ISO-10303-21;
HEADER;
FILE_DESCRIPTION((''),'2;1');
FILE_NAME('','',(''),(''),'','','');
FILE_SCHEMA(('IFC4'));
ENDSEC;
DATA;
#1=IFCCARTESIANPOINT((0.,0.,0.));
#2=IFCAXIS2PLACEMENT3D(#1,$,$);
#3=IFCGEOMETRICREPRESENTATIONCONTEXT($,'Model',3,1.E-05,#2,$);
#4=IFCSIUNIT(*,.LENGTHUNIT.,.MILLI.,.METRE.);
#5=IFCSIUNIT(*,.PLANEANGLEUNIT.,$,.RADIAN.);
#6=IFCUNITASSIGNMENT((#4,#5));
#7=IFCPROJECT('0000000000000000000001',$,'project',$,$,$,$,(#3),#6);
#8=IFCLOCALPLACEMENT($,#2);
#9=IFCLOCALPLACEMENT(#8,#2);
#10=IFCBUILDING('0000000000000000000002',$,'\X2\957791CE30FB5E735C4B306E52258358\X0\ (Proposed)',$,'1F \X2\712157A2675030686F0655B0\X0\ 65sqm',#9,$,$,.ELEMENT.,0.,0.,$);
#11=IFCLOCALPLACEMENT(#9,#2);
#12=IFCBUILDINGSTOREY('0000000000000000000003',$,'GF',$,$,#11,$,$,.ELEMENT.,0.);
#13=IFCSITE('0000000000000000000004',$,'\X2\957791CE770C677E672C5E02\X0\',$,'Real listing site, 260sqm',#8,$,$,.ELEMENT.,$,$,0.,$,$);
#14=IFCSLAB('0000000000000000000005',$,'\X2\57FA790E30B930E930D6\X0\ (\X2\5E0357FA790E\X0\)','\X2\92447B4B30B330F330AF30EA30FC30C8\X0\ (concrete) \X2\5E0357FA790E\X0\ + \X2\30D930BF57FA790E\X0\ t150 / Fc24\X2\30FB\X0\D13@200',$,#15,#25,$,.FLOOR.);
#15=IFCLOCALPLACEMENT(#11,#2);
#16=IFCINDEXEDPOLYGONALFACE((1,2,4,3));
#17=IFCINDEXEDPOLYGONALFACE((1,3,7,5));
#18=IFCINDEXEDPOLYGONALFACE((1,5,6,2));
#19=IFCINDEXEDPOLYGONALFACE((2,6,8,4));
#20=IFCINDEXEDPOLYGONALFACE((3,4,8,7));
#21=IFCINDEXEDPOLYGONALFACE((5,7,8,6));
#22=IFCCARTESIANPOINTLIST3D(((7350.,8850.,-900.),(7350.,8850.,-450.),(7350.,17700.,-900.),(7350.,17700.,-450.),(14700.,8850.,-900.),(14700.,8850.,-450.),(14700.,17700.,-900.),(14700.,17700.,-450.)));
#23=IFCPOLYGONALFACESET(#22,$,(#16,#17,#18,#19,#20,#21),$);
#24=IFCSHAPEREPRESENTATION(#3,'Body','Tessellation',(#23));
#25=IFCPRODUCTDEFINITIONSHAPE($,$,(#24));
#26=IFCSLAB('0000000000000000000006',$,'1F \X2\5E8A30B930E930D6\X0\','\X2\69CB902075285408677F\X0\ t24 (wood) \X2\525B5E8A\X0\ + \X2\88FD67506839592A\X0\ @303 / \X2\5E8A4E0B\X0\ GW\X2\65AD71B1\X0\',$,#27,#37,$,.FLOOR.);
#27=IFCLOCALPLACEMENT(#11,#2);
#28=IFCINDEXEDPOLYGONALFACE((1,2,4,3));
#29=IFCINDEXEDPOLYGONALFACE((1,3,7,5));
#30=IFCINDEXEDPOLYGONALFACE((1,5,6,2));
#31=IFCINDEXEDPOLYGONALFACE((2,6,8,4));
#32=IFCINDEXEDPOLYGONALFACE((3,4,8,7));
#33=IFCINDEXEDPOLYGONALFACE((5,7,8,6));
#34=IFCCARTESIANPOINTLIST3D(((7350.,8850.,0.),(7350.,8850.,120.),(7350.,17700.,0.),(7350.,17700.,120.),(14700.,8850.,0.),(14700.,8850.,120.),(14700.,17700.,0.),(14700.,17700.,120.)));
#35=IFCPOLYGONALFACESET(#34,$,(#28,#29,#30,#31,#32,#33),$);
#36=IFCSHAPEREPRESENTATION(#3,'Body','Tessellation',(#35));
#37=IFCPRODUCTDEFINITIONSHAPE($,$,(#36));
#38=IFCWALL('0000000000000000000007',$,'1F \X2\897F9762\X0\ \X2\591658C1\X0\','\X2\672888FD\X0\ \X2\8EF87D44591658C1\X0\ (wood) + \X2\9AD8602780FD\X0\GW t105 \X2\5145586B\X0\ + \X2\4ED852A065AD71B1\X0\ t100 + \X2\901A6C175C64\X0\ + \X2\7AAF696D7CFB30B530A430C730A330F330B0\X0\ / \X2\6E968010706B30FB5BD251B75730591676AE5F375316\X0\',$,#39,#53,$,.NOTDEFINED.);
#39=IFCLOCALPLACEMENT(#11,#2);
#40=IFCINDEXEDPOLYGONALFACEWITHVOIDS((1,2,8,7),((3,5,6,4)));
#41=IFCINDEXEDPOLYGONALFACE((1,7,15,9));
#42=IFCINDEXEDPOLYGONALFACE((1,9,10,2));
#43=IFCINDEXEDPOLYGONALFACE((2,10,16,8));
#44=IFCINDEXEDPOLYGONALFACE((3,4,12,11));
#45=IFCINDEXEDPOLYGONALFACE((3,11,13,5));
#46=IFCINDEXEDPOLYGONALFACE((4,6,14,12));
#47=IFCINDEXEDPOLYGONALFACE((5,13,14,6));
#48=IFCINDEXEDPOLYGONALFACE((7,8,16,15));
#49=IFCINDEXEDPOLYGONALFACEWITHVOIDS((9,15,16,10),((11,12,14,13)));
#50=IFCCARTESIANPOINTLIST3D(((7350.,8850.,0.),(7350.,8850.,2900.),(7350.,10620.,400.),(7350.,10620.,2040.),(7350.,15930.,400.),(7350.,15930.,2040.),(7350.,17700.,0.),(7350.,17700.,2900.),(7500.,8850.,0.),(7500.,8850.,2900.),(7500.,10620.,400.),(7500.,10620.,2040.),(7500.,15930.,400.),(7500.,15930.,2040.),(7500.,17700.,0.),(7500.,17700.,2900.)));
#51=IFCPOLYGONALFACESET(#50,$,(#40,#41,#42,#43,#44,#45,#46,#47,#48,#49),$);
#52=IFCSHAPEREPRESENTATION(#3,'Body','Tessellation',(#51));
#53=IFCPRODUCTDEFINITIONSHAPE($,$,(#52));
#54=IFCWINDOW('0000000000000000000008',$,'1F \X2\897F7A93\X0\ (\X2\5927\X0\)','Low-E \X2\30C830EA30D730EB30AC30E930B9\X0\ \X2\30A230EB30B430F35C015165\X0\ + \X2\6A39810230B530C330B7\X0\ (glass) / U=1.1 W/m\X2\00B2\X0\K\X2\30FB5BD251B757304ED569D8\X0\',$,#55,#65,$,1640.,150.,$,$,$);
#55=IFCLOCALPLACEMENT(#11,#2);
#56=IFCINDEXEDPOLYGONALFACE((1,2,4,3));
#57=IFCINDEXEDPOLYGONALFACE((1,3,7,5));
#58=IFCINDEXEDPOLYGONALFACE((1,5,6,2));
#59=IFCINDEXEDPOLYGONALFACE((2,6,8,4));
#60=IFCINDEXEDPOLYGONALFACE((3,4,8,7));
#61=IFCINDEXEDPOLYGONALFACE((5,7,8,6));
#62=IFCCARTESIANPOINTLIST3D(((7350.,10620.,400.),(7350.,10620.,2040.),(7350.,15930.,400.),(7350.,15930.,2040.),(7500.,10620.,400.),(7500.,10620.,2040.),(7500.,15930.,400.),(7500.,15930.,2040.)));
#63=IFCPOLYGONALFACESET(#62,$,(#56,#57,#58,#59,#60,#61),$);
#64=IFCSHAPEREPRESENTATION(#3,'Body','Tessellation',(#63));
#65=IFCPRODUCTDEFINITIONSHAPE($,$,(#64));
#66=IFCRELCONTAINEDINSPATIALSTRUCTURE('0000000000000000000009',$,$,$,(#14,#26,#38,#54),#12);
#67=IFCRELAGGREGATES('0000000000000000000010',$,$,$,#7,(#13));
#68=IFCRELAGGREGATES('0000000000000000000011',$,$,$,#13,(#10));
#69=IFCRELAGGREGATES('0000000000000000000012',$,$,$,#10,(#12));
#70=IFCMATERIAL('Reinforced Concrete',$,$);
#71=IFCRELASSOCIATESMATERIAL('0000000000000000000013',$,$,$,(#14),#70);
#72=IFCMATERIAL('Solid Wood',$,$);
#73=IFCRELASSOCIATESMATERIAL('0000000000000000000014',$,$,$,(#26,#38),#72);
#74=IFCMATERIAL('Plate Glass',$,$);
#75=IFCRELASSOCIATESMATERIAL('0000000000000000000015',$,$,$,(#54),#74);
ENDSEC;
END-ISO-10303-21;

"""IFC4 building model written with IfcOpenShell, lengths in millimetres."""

from ifc_helpers import new_model, si_unit, frame, frame_2d, origin, place, context, project, spatial, rectangle, extrude, material, element, fill, save


model = new_model("IFC4")

# Units and contexts
model_context = context("Model", 3, precision=1e-05, world=origin())
ifc_project = project(units=[si_unit("LENGTHUNIT", "METRE", prefix="MILLI"), si_unit("PLANEANGLEUNIT", "RADIAN")], contexts=[model_context])

# Site, building, storey
site_placement = place(None, origin())
site = spatial("IfcSite", under=ifc_project, at=site_placement, Name="長野県松本市", ObjectType="Real listing site, 260sqm", CompositionType="ELEMENT", RefElevation=0.0)
building_placement = place(site_placement, origin())
building = spatial("IfcBuilding", under=site, at=building_placement, Name="長野・平屋の別荘 (Proposed)", ObjectType="1F 無垢材と漆喰 65sqm", CompositionType="ELEMENT", ElevationOfRefHeight=0.0, ElevationOfTerrain=0.0)
storey_placement = place(building_placement, origin())
storey = spatial("IfcBuildingStorey", under=building, at=storey_placement, Name="GF", CompositionType="ELEMENT", Elevation=0.0)

# Shared definitions
ifc_material_1 = material(Name="Solid Wood")

# Slabs
ifc_material_2 = material(Name="Reinforced Concrete")
slab_1_placement = place(storey_placement, frame((3675.0, 4425.0, -450.0)))
element("IfcSlab", 1, at=slab_1_placement, inside=storey, material=ifc_material_2, Name="基礎スラブ (布基礎)", Description="鉄筋コンクリート (concrete) 布基礎 + ベタ基礎 t150 / Fc24・D13@200", PredefinedType="FLOOR", context=model_context, shape_type="SweptSolid", body=[
    extrude(rectangle(XDim=7350.0, YDim=8850.0, at=frame_2d((3675.0, 4425.0))), frame((3675.0, 4425.0, -450.0)), (0.0, 0.0, 1.0), 450.0),
])
slab_2_placement = place(storey_placement, frame((3675.0, 4425.0, 0.0)))
element("IfcSlab", 2, at=slab_2_placement, inside=storey, material=ifc_material_1, Name="1F 床スラブ", Description="構造用合板 t24 (wood) 剛床 + 製材根太 @303 / 床下 GW断熱", PredefinedType="FLOOR", context=model_context, shape_type="SweptSolid", body=[
    extrude(rectangle(XDim=7350.0, YDim=8850.0, at=frame_2d((3675.0, 4425.0))), frame((3675.0, 4425.0, 0.0)), (0.0, 0.0, 1.0), 120.0),
])

# Shared definitions
ifc_material_3 = material(Name="Plate Glass")

# Wall, opening, window
wall_1_placement = place(storey_placement, frame((3675.0, 4425.0, 0.0)))
wall_1 = element("IfcWall", 3, at=wall_1_placement, inside=storey, material=ifc_material_1, Name="1F 西面 外壁", Description="木製 軸組外壁 (wood) + 高性能GW t105 充填 + 付加断熱 t100 + 通気層 + 窯業系サイディング / 準耐火・寒冷地外皮強化", PredefinedType="NOTDEFINED", context=model_context, shape_type="SweptSolid", body=[
    extrude(rectangle(XDim=150.0, YDim=8850.0, at=frame_2d((75.0, 4425.0))), frame((3675.0, 4425.0, 0.0)), (0.0, 0.0, 1.0), 2900.0),
])
opening_1_placement = place(storey_placement, frame((3675.0, 5310.0, 200.0)))
opening_1 = element("IfcOpeningElement", 4, at=opening_1_placement, cuts=wall_1, PredefinedType="NOTDEFINED", context=model_context, shape_type="SweptSolid", body=[
    extrude(rectangle(XDim=150.0, YDim=5310.0, at=frame_2d((75.0, 2655.0))), frame((3675.0, 5310.0, 200.0)), (0.0, 0.0, 1.0), 1640.0),
])
window_1_placement = place(storey_placement, frame((3675.0, 5310.0, 200.0)))
window_1 = element("IfcWindow", 5, at=window_1_placement, inside=storey, material=ifc_material_3, Name="1F 西窓 (大)", Description="Low-E トリプルガラス アルゴン封入 + 樹脂サッシ (glass) / U=1.1 W/m²K・寒冷地仕様", OverallHeight=1640.0, OverallWidth=150.0, context=model_context, shape_type="SweptSolid", body=[
    extrude(rectangle(XDim=150.0, YDim=5310.0, at=frame_2d((75.0, 2655.0))), frame((3675.0, 5310.0, 200.0)), (0.0, 0.0, 1.0), 1640.0),
])
fill(opening_1, window_1)

save(model, "model.ifc")
